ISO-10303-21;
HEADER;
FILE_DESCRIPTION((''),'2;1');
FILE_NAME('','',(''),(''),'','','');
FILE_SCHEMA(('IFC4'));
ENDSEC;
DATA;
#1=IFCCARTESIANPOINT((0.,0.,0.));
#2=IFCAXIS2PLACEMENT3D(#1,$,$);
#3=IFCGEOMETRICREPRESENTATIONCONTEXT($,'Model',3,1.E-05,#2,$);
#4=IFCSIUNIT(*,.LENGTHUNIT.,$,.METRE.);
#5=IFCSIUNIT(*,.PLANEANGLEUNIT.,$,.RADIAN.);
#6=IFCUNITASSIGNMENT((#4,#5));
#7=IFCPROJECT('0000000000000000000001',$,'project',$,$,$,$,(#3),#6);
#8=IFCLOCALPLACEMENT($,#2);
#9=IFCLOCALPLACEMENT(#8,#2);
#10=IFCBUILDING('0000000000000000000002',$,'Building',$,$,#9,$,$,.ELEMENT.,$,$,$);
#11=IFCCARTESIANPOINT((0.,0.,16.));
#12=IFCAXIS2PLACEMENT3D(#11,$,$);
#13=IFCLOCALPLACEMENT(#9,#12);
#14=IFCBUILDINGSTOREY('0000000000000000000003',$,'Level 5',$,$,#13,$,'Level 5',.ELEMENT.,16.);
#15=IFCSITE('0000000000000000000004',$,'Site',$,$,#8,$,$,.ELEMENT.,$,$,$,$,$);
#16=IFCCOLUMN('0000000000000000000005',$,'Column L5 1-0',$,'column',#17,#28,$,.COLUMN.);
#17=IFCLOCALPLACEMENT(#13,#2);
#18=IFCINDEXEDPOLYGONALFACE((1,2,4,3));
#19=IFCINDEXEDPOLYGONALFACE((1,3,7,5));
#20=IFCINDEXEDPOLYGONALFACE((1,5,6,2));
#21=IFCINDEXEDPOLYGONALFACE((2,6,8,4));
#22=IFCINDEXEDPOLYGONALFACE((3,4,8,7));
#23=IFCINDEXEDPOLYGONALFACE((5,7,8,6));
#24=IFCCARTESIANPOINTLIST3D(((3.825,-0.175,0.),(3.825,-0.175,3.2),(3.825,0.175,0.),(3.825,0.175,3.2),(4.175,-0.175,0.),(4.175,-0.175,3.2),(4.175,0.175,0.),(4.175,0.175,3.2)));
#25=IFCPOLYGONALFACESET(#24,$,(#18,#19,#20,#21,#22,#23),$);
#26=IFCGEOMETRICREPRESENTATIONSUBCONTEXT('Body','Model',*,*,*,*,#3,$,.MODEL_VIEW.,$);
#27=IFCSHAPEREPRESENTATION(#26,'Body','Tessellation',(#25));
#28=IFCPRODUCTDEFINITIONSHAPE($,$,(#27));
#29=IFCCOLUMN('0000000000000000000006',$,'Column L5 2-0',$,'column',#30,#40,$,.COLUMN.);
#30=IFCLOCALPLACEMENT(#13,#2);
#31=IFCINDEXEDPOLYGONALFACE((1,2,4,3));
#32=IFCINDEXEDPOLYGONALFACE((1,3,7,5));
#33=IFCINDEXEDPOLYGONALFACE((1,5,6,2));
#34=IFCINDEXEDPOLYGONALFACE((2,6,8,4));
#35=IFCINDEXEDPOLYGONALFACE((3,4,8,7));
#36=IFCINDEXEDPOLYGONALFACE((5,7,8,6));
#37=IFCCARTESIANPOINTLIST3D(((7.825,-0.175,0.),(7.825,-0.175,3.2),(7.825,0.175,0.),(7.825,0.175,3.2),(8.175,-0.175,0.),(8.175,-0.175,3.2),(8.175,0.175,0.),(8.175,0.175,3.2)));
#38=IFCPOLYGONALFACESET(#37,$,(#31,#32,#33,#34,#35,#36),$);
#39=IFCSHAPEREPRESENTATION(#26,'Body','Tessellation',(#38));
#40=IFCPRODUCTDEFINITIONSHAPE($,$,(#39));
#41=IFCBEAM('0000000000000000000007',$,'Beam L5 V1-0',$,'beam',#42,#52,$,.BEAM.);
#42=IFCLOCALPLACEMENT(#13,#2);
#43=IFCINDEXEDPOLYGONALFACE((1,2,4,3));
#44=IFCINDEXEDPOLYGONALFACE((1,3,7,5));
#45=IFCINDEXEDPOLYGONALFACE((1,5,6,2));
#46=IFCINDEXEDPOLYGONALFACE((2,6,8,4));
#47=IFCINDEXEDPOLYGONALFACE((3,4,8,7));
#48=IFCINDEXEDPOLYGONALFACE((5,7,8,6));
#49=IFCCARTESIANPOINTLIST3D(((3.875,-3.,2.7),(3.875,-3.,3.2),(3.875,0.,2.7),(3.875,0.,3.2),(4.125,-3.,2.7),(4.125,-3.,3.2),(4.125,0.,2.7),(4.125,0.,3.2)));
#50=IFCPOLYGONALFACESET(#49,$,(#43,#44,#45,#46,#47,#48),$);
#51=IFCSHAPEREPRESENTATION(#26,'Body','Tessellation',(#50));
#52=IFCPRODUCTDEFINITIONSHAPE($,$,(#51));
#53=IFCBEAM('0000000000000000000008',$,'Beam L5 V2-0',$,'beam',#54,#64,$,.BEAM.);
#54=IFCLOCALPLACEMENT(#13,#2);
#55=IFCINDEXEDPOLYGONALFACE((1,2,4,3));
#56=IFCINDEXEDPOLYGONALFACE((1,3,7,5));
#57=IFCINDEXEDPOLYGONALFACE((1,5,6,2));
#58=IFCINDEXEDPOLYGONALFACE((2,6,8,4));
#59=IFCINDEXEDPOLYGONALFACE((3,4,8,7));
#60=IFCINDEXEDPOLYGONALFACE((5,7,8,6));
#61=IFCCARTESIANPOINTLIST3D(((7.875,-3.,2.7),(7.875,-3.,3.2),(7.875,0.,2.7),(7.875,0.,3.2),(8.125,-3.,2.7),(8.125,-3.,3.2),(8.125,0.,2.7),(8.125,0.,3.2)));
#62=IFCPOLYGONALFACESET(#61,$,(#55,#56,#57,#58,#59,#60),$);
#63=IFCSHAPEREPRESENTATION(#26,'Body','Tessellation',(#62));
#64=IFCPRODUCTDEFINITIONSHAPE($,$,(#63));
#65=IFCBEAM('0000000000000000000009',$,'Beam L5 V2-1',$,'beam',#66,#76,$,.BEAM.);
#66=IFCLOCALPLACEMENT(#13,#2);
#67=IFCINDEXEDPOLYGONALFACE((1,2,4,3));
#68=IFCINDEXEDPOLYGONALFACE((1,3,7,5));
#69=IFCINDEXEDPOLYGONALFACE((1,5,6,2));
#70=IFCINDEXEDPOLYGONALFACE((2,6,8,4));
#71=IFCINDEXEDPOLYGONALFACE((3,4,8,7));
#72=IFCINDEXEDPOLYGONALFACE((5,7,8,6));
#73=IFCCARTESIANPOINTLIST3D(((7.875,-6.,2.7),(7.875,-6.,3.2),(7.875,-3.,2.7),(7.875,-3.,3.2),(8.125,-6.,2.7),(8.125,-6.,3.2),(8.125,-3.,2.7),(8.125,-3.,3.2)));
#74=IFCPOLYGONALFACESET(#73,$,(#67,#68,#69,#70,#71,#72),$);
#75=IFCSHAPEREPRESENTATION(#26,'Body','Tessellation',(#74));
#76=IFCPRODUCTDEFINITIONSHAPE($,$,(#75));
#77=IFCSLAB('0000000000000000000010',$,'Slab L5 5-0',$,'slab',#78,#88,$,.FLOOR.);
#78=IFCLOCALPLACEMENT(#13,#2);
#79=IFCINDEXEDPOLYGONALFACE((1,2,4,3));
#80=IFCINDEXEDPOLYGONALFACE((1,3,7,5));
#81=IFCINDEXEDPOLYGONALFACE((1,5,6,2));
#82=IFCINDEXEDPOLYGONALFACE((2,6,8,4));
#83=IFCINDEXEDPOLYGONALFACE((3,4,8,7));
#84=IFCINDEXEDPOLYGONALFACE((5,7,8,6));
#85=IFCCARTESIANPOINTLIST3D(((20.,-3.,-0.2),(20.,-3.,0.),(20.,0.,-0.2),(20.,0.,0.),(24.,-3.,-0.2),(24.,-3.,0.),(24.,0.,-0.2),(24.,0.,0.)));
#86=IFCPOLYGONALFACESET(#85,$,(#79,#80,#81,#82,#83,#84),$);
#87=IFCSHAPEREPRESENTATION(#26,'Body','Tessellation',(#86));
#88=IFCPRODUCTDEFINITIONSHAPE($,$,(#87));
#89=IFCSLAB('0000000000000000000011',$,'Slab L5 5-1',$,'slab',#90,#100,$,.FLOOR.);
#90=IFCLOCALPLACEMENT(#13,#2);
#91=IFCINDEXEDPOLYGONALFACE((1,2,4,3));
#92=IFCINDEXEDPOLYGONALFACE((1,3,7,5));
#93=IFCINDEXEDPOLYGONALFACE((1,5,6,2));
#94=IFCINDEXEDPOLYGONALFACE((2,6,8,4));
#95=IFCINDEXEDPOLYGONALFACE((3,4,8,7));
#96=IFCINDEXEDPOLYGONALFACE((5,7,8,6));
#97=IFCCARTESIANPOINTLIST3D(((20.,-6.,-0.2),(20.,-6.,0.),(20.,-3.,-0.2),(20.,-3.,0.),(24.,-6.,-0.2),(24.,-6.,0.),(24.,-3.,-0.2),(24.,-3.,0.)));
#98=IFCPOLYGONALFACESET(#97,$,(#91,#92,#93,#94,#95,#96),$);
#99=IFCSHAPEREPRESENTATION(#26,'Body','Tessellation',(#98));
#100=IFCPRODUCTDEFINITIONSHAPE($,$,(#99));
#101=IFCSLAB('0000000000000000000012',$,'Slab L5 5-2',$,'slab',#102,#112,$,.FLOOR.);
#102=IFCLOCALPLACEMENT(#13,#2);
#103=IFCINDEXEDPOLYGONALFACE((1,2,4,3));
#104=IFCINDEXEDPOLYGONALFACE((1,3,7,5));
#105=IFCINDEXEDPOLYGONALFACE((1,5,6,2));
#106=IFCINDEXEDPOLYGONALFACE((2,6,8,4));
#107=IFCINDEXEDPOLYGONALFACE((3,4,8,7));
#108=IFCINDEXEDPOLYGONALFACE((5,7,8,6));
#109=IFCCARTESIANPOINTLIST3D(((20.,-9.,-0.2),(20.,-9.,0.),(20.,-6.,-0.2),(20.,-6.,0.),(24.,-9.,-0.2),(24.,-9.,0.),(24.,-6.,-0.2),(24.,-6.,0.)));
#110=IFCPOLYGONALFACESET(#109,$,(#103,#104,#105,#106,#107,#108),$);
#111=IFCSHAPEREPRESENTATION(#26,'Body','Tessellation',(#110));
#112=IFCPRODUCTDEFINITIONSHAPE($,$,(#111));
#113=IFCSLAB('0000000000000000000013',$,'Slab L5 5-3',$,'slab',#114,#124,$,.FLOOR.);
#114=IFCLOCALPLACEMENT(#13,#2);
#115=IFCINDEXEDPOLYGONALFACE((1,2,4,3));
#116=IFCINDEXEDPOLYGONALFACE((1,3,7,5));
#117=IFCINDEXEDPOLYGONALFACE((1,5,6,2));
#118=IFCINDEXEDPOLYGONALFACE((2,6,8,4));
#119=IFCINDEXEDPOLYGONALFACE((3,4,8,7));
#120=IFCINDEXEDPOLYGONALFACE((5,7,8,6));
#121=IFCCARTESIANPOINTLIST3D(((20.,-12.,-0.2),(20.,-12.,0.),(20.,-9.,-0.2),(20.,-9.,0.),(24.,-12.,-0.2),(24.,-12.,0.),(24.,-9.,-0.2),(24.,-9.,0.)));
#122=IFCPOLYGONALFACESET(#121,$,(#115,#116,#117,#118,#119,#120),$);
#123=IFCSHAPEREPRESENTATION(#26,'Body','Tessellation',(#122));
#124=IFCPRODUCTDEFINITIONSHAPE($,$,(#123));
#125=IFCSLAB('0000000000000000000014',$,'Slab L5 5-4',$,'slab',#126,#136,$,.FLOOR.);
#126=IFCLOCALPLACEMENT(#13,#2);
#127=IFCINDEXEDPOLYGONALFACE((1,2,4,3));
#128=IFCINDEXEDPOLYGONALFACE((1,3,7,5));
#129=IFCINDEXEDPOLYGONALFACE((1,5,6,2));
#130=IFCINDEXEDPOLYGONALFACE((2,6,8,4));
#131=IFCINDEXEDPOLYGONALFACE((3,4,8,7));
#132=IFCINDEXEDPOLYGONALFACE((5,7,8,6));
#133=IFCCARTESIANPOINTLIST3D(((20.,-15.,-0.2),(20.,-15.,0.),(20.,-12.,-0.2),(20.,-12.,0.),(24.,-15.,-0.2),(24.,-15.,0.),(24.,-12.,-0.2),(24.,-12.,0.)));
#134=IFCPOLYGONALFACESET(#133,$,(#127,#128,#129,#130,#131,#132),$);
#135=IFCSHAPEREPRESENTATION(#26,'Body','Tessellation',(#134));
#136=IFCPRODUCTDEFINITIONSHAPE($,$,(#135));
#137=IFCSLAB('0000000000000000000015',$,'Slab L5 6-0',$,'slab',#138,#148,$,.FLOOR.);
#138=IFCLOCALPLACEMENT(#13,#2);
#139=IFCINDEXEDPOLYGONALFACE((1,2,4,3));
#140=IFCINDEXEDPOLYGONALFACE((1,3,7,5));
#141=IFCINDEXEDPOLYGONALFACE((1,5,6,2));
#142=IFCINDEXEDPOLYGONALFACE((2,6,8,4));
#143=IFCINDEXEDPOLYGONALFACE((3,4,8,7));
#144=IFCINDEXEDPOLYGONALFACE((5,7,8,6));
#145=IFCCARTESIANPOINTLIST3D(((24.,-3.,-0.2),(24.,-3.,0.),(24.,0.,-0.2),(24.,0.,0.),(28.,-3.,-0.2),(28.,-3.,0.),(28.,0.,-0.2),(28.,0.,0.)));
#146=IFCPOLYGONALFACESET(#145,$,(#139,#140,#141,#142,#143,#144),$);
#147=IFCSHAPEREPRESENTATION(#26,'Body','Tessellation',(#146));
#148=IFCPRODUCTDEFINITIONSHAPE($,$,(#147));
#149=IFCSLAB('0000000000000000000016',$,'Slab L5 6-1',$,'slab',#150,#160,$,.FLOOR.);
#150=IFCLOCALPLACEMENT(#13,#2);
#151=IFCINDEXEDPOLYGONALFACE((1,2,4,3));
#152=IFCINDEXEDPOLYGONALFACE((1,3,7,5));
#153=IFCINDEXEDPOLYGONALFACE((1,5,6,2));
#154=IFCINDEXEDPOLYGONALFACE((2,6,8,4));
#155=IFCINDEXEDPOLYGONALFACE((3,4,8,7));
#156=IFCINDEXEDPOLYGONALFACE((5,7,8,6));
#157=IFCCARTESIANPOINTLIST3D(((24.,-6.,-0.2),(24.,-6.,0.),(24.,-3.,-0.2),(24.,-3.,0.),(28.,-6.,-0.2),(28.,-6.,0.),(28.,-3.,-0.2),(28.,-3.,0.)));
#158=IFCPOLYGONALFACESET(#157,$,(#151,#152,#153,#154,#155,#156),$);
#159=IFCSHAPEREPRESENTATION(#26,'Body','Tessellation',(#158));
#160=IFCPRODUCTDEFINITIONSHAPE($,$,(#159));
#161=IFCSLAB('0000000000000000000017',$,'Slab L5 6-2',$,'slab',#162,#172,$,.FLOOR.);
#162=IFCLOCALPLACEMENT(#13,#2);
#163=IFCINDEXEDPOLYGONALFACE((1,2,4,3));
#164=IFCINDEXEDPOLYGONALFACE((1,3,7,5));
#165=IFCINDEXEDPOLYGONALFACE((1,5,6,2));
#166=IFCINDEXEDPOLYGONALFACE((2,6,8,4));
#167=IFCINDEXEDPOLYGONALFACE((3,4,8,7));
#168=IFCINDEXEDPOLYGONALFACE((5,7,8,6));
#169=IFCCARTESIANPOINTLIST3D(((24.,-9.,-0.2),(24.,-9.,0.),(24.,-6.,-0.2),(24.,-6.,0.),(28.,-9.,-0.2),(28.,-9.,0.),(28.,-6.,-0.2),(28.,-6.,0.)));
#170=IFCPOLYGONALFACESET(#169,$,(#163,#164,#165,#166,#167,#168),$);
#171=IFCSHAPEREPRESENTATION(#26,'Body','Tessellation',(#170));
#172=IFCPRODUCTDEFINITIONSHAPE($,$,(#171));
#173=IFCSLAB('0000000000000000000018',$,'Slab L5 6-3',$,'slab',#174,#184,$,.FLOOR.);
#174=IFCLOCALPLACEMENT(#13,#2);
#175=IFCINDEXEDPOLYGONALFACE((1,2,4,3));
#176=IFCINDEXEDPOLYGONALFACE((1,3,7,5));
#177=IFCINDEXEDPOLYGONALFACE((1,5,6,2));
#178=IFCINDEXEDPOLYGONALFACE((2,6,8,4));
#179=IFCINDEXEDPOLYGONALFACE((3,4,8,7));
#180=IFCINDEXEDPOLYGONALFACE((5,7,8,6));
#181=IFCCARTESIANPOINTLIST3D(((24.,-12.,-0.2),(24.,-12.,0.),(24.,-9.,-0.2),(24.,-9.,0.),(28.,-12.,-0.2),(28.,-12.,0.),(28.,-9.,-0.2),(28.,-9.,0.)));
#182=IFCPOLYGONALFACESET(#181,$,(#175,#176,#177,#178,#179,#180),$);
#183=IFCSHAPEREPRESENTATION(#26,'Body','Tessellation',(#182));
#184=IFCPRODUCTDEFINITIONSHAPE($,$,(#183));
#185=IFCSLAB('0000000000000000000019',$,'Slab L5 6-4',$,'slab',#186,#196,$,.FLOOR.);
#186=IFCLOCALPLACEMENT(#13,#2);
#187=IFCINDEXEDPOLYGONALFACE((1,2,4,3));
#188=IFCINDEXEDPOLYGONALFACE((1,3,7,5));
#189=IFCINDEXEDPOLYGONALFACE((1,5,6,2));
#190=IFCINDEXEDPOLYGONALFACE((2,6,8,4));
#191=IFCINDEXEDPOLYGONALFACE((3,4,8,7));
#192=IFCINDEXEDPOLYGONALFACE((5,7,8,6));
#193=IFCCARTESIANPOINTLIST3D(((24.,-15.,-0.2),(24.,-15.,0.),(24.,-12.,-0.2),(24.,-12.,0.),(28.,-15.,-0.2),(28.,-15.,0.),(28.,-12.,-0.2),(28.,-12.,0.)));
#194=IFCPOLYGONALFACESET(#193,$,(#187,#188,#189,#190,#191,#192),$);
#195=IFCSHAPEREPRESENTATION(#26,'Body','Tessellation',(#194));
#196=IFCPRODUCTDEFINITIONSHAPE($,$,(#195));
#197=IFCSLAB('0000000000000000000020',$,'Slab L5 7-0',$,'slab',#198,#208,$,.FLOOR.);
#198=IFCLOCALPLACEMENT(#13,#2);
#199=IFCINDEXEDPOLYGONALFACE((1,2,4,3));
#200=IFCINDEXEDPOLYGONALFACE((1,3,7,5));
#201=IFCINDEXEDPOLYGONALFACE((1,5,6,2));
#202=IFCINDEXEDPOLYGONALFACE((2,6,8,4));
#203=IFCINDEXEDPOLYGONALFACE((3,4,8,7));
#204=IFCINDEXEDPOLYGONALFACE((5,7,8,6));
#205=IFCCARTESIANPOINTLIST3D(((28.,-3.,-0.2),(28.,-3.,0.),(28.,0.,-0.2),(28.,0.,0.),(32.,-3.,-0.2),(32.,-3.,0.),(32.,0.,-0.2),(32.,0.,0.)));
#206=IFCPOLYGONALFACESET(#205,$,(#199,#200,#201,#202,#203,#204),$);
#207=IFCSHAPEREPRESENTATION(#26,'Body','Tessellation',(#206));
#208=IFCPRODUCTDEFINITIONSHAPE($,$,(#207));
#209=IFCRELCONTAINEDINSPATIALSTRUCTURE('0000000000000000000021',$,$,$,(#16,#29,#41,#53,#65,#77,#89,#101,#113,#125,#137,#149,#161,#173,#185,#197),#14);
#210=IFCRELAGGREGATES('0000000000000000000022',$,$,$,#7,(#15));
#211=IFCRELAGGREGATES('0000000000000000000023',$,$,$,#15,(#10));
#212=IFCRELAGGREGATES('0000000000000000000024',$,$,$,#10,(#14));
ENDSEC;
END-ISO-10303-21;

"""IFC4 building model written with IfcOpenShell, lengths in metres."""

from ifc_helpers import new_model, si_unit, frame, origin, origin_2d, place, context, subcontext, project, spatial, polyline, rectangle, outline, extrude, element, save


model = new_model("IFC4")

# Units and contexts
model_context = context("Model", 3, precision=1e-05, world=origin())
body_context = subcontext(model_context, "Body", "Model", "MODEL_VIEW")
ifc_project = project(units=[si_unit("LENGTHUNIT", "METRE"), si_unit("PLANEANGLEUNIT", "RADIAN")], contexts=[model_context])

# Site, building, storey
site_placement = place(None, origin())
site = spatial("IfcSite", under=ifc_project, at=site_placement, Name="Site", CompositionType="ELEMENT")
building_placement = place(site_placement, origin())
building = spatial("IfcBuilding", under=site, at=building_placement, Name="Building", CompositionType="ELEMENT")
storey_placement = place(building_placement, frame((0.0, 0.0, 16.0)))
storey = spatial("IfcBuildingStorey", under=building, at=storey_placement, Name="Level 5", LongName="Level 5", CompositionType="ELEMENT", Elevation=16.0)

# Columns
for number, where, name in (
    (1, (4.0, 0.0, 0.0), "Column L5 1-0"),
    (2, (8.0, 0.0, 0.0), "Column L5 2-0"),
):
    element("IfcColumn", number, at=place(storey_placement, frame(where)), inside=storey, Name=name, ObjectType="column", PredefinedType="COLUMN", context=body_context, shape_type="SweptSolid", body=[
        extrude(rectangle(XDim=0.35, YDim=0.35, at=origin_2d()), origin(), (0.0, 0.0, 1.0), 3.2),
    ])

# Beams
for number, where, z_axis, x_axis, name in (
    (3, (4.0, 0.0, 2.95), (0.0, -1.0, 0.0), (0.0, 0.0, 1.0), "Beam L5 V1-0"),
    (4, (8.0, 0.0, 2.95), (0.0, -1.0, 0.0), (0.0, 0.0, 1.0), "Beam L5 V2-0"),
    (5, (8.0, -3.0, 2.95), (0.0, -1.0, 0.0), (0.0, 0.0, 1.0), "Beam L5 V2-1"),
):
    element("IfcBeam", number, at=place(storey_placement, frame(where, z_axis=z_axis, x_axis=x_axis)), inside=storey, Name=name, ObjectType="beam", PredefinedType="BEAM", context=body_context, shape_type="SweptSolid", body=[
        extrude(rectangle(XDim=0.5, YDim=0.25, at=origin_2d()), origin(), (0.0, 0.0, 1.0), 3.0),
    ])

# Slabs
slab_1_placement = place(storey_placement, frame((0.0, 0.0, -0.2)))
element("IfcSlab", 6, at=slab_1_placement, inside=storey, Name="Slab L5 5-0", ObjectType="slab", PredefinedType="FLOOR", context=body_context, shape_type="SweptSolid", body=[
    extrude(outline(polyline([(20.0, -3.0), (24.0, -3.0), (24.0, 0.0), (20.0, 0.0), (20.0, -3.0)])), origin(), (0.0, 0.0, 1.0), 0.2),
])
slab_2_placement = place(storey_placement, frame((0.0, 0.0, -0.2)))
element("IfcSlab", 7, at=slab_2_placement, inside=storey, Name="Slab L5 5-1", ObjectType="slab", PredefinedType="FLOOR", context=body_context, shape_type="SweptSolid", body=[
    extrude(outline(polyline([(20.0, -6.0), (24.0, -6.0), (24.0, -3.0), (20.0, -3.0), (20.0, -6.0)])), origin(), (0.0, 0.0, 1.0), 0.2),
])
slab_3_placement = place(storey_placement, frame((0.0, 0.0, -0.2)))
element("IfcSlab", 8, at=slab_3_placement, inside=storey, Name="Slab L5 5-2", ObjectType="slab", PredefinedType="FLOOR", context=body_context, shape_type="SweptSolid", body=[
    extrude(outline(polyline([(20.0, -9.0), (24.0, -9.0), (24.0, -6.0), (20.0, -6.0), (20.0, -9.0)])), origin(), (0.0, 0.0, 1.0), 0.2),
])
slab_4_placement = place(storey_placement, frame((0.0, 0.0, -0.2)))
element("IfcSlab", 9, at=slab_4_placement, inside=storey, Name="Slab L5 5-3", ObjectType="slab", PredefinedType="FLOOR", context=body_context, shape_type="SweptSolid", body=[
    extrude(outline(polyline([(20.0, -12.0), (24.0, -12.0), (24.0, -9.0), (20.0, -9.0), (20.0, -12.0)])), origin(), (0.0, 0.0, 1.0), 0.2),
])
slab_5_placement = place(storey_placement, frame((0.0, 0.0, -0.2)))
element("IfcSlab", 10, at=slab_5_placement, inside=storey, Name="Slab L5 5-4", ObjectType="slab", PredefinedType="FLOOR", context=body_context, shape_type="SweptSolid", body=[
    extrude(outline(polyline([(20.0, -15.0), (24.0, -15.0), (24.0, -12.0), (20.0, -12.0), (20.0, -15.0)])), origin(), (0.0, 0.0, 1.0), 0.2),
])
slab_6_placement = place(storey_placement, frame((0.0, 0.0, -0.2)))
element("IfcSlab", 11, at=slab_6_placement, inside=storey, Name="Slab L5 6-0", ObjectType="slab", PredefinedType="FLOOR", context=body_context, shape_type="SweptSolid", body=[
    extrude(outline(polyline([(24.0, -3.0), (28.0, -3.0), (28.0, 0.0), (24.0, 0.0), (24.0, -3.0)])), origin(), (0.0, 0.0, 1.0), 0.2),
])
slab_7_placement = place(storey_placement, frame((0.0, 0.0, -0.2)))
element("IfcSlab", 12, at=slab_7_placement, inside=storey, Name="Slab L5 6-1", ObjectType="slab", PredefinedType="FLOOR", context=body_context, shape_type="SweptSolid", body=[
    extrude(outline(polyline([(24.0, -6.0), (28.0, -6.0), (28.0, -3.0), (24.0, -3.0), (24.0, -6.0)])), origin(), (0.0, 0.0, 1.0), 0.2),
])
slab_8_placement = place(storey_placement, frame((0.0, 0.0, -0.2)))
element("IfcSlab", 13, at=slab_8_placement, inside=storey, Name="Slab L5 6-2", ObjectType="slab", PredefinedType="FLOOR", context=body_context, shape_type="SweptSolid", body=[
    extrude(outline(polyline([(24.0, -9.0), (28.0, -9.0), (28.0, -6.0), (24.0, -6.0), (24.0, -9.0)])), origin(), (0.0, 0.0, 1.0), 0.2),
])
slab_9_placement = place(storey_placement, frame((0.0, 0.0, -0.2)))
element("IfcSlab", 14, at=slab_9_placement, inside=storey, Name="Slab L5 6-3", ObjectType="slab", PredefinedType="FLOOR", context=body_context, shape_type="SweptSolid", body=[
    extrude(outline(polyline([(24.0, -12.0), (28.0, -12.0), (28.0, -9.0), (24.0, -9.0), (24.0, -12.0)])), origin(), (0.0, 0.0, 1.0), 0.2),
])
slab_10_placement = place(storey_placement, frame((0.0, 0.0, -0.2)))
element("IfcSlab", 15, at=slab_10_placement, inside=storey, Name="Slab L5 6-4", ObjectType="slab", PredefinedType="FLOOR", context=body_context, shape_type="SweptSolid", body=[
    extrude(outline(polyline([(24.0, -15.0), (28.0, -15.0), (28.0, -12.0), (24.0, -12.0), (24.0, -15.0)])), origin(), (0.0, 0.0, 1.0), 0.2),
])
slab_11_placement = place(storey_placement, frame((0.0, 0.0, -0.2)))
element("IfcSlab", 16, at=slab_11_placement, inside=storey, Name="Slab L5 7-0", ObjectType="slab", PredefinedType="FLOOR", context=body_context, shape_type="SweptSolid", body=[
    extrude(outline(polyline([(28.0, -3.0), (32.0, -3.0), (32.0, 0.0), (28.0, 0.0), (28.0, -3.0)])), origin(), (0.0, 0.0, 1.0), 0.2),
])

save(model, "model.ifc")
